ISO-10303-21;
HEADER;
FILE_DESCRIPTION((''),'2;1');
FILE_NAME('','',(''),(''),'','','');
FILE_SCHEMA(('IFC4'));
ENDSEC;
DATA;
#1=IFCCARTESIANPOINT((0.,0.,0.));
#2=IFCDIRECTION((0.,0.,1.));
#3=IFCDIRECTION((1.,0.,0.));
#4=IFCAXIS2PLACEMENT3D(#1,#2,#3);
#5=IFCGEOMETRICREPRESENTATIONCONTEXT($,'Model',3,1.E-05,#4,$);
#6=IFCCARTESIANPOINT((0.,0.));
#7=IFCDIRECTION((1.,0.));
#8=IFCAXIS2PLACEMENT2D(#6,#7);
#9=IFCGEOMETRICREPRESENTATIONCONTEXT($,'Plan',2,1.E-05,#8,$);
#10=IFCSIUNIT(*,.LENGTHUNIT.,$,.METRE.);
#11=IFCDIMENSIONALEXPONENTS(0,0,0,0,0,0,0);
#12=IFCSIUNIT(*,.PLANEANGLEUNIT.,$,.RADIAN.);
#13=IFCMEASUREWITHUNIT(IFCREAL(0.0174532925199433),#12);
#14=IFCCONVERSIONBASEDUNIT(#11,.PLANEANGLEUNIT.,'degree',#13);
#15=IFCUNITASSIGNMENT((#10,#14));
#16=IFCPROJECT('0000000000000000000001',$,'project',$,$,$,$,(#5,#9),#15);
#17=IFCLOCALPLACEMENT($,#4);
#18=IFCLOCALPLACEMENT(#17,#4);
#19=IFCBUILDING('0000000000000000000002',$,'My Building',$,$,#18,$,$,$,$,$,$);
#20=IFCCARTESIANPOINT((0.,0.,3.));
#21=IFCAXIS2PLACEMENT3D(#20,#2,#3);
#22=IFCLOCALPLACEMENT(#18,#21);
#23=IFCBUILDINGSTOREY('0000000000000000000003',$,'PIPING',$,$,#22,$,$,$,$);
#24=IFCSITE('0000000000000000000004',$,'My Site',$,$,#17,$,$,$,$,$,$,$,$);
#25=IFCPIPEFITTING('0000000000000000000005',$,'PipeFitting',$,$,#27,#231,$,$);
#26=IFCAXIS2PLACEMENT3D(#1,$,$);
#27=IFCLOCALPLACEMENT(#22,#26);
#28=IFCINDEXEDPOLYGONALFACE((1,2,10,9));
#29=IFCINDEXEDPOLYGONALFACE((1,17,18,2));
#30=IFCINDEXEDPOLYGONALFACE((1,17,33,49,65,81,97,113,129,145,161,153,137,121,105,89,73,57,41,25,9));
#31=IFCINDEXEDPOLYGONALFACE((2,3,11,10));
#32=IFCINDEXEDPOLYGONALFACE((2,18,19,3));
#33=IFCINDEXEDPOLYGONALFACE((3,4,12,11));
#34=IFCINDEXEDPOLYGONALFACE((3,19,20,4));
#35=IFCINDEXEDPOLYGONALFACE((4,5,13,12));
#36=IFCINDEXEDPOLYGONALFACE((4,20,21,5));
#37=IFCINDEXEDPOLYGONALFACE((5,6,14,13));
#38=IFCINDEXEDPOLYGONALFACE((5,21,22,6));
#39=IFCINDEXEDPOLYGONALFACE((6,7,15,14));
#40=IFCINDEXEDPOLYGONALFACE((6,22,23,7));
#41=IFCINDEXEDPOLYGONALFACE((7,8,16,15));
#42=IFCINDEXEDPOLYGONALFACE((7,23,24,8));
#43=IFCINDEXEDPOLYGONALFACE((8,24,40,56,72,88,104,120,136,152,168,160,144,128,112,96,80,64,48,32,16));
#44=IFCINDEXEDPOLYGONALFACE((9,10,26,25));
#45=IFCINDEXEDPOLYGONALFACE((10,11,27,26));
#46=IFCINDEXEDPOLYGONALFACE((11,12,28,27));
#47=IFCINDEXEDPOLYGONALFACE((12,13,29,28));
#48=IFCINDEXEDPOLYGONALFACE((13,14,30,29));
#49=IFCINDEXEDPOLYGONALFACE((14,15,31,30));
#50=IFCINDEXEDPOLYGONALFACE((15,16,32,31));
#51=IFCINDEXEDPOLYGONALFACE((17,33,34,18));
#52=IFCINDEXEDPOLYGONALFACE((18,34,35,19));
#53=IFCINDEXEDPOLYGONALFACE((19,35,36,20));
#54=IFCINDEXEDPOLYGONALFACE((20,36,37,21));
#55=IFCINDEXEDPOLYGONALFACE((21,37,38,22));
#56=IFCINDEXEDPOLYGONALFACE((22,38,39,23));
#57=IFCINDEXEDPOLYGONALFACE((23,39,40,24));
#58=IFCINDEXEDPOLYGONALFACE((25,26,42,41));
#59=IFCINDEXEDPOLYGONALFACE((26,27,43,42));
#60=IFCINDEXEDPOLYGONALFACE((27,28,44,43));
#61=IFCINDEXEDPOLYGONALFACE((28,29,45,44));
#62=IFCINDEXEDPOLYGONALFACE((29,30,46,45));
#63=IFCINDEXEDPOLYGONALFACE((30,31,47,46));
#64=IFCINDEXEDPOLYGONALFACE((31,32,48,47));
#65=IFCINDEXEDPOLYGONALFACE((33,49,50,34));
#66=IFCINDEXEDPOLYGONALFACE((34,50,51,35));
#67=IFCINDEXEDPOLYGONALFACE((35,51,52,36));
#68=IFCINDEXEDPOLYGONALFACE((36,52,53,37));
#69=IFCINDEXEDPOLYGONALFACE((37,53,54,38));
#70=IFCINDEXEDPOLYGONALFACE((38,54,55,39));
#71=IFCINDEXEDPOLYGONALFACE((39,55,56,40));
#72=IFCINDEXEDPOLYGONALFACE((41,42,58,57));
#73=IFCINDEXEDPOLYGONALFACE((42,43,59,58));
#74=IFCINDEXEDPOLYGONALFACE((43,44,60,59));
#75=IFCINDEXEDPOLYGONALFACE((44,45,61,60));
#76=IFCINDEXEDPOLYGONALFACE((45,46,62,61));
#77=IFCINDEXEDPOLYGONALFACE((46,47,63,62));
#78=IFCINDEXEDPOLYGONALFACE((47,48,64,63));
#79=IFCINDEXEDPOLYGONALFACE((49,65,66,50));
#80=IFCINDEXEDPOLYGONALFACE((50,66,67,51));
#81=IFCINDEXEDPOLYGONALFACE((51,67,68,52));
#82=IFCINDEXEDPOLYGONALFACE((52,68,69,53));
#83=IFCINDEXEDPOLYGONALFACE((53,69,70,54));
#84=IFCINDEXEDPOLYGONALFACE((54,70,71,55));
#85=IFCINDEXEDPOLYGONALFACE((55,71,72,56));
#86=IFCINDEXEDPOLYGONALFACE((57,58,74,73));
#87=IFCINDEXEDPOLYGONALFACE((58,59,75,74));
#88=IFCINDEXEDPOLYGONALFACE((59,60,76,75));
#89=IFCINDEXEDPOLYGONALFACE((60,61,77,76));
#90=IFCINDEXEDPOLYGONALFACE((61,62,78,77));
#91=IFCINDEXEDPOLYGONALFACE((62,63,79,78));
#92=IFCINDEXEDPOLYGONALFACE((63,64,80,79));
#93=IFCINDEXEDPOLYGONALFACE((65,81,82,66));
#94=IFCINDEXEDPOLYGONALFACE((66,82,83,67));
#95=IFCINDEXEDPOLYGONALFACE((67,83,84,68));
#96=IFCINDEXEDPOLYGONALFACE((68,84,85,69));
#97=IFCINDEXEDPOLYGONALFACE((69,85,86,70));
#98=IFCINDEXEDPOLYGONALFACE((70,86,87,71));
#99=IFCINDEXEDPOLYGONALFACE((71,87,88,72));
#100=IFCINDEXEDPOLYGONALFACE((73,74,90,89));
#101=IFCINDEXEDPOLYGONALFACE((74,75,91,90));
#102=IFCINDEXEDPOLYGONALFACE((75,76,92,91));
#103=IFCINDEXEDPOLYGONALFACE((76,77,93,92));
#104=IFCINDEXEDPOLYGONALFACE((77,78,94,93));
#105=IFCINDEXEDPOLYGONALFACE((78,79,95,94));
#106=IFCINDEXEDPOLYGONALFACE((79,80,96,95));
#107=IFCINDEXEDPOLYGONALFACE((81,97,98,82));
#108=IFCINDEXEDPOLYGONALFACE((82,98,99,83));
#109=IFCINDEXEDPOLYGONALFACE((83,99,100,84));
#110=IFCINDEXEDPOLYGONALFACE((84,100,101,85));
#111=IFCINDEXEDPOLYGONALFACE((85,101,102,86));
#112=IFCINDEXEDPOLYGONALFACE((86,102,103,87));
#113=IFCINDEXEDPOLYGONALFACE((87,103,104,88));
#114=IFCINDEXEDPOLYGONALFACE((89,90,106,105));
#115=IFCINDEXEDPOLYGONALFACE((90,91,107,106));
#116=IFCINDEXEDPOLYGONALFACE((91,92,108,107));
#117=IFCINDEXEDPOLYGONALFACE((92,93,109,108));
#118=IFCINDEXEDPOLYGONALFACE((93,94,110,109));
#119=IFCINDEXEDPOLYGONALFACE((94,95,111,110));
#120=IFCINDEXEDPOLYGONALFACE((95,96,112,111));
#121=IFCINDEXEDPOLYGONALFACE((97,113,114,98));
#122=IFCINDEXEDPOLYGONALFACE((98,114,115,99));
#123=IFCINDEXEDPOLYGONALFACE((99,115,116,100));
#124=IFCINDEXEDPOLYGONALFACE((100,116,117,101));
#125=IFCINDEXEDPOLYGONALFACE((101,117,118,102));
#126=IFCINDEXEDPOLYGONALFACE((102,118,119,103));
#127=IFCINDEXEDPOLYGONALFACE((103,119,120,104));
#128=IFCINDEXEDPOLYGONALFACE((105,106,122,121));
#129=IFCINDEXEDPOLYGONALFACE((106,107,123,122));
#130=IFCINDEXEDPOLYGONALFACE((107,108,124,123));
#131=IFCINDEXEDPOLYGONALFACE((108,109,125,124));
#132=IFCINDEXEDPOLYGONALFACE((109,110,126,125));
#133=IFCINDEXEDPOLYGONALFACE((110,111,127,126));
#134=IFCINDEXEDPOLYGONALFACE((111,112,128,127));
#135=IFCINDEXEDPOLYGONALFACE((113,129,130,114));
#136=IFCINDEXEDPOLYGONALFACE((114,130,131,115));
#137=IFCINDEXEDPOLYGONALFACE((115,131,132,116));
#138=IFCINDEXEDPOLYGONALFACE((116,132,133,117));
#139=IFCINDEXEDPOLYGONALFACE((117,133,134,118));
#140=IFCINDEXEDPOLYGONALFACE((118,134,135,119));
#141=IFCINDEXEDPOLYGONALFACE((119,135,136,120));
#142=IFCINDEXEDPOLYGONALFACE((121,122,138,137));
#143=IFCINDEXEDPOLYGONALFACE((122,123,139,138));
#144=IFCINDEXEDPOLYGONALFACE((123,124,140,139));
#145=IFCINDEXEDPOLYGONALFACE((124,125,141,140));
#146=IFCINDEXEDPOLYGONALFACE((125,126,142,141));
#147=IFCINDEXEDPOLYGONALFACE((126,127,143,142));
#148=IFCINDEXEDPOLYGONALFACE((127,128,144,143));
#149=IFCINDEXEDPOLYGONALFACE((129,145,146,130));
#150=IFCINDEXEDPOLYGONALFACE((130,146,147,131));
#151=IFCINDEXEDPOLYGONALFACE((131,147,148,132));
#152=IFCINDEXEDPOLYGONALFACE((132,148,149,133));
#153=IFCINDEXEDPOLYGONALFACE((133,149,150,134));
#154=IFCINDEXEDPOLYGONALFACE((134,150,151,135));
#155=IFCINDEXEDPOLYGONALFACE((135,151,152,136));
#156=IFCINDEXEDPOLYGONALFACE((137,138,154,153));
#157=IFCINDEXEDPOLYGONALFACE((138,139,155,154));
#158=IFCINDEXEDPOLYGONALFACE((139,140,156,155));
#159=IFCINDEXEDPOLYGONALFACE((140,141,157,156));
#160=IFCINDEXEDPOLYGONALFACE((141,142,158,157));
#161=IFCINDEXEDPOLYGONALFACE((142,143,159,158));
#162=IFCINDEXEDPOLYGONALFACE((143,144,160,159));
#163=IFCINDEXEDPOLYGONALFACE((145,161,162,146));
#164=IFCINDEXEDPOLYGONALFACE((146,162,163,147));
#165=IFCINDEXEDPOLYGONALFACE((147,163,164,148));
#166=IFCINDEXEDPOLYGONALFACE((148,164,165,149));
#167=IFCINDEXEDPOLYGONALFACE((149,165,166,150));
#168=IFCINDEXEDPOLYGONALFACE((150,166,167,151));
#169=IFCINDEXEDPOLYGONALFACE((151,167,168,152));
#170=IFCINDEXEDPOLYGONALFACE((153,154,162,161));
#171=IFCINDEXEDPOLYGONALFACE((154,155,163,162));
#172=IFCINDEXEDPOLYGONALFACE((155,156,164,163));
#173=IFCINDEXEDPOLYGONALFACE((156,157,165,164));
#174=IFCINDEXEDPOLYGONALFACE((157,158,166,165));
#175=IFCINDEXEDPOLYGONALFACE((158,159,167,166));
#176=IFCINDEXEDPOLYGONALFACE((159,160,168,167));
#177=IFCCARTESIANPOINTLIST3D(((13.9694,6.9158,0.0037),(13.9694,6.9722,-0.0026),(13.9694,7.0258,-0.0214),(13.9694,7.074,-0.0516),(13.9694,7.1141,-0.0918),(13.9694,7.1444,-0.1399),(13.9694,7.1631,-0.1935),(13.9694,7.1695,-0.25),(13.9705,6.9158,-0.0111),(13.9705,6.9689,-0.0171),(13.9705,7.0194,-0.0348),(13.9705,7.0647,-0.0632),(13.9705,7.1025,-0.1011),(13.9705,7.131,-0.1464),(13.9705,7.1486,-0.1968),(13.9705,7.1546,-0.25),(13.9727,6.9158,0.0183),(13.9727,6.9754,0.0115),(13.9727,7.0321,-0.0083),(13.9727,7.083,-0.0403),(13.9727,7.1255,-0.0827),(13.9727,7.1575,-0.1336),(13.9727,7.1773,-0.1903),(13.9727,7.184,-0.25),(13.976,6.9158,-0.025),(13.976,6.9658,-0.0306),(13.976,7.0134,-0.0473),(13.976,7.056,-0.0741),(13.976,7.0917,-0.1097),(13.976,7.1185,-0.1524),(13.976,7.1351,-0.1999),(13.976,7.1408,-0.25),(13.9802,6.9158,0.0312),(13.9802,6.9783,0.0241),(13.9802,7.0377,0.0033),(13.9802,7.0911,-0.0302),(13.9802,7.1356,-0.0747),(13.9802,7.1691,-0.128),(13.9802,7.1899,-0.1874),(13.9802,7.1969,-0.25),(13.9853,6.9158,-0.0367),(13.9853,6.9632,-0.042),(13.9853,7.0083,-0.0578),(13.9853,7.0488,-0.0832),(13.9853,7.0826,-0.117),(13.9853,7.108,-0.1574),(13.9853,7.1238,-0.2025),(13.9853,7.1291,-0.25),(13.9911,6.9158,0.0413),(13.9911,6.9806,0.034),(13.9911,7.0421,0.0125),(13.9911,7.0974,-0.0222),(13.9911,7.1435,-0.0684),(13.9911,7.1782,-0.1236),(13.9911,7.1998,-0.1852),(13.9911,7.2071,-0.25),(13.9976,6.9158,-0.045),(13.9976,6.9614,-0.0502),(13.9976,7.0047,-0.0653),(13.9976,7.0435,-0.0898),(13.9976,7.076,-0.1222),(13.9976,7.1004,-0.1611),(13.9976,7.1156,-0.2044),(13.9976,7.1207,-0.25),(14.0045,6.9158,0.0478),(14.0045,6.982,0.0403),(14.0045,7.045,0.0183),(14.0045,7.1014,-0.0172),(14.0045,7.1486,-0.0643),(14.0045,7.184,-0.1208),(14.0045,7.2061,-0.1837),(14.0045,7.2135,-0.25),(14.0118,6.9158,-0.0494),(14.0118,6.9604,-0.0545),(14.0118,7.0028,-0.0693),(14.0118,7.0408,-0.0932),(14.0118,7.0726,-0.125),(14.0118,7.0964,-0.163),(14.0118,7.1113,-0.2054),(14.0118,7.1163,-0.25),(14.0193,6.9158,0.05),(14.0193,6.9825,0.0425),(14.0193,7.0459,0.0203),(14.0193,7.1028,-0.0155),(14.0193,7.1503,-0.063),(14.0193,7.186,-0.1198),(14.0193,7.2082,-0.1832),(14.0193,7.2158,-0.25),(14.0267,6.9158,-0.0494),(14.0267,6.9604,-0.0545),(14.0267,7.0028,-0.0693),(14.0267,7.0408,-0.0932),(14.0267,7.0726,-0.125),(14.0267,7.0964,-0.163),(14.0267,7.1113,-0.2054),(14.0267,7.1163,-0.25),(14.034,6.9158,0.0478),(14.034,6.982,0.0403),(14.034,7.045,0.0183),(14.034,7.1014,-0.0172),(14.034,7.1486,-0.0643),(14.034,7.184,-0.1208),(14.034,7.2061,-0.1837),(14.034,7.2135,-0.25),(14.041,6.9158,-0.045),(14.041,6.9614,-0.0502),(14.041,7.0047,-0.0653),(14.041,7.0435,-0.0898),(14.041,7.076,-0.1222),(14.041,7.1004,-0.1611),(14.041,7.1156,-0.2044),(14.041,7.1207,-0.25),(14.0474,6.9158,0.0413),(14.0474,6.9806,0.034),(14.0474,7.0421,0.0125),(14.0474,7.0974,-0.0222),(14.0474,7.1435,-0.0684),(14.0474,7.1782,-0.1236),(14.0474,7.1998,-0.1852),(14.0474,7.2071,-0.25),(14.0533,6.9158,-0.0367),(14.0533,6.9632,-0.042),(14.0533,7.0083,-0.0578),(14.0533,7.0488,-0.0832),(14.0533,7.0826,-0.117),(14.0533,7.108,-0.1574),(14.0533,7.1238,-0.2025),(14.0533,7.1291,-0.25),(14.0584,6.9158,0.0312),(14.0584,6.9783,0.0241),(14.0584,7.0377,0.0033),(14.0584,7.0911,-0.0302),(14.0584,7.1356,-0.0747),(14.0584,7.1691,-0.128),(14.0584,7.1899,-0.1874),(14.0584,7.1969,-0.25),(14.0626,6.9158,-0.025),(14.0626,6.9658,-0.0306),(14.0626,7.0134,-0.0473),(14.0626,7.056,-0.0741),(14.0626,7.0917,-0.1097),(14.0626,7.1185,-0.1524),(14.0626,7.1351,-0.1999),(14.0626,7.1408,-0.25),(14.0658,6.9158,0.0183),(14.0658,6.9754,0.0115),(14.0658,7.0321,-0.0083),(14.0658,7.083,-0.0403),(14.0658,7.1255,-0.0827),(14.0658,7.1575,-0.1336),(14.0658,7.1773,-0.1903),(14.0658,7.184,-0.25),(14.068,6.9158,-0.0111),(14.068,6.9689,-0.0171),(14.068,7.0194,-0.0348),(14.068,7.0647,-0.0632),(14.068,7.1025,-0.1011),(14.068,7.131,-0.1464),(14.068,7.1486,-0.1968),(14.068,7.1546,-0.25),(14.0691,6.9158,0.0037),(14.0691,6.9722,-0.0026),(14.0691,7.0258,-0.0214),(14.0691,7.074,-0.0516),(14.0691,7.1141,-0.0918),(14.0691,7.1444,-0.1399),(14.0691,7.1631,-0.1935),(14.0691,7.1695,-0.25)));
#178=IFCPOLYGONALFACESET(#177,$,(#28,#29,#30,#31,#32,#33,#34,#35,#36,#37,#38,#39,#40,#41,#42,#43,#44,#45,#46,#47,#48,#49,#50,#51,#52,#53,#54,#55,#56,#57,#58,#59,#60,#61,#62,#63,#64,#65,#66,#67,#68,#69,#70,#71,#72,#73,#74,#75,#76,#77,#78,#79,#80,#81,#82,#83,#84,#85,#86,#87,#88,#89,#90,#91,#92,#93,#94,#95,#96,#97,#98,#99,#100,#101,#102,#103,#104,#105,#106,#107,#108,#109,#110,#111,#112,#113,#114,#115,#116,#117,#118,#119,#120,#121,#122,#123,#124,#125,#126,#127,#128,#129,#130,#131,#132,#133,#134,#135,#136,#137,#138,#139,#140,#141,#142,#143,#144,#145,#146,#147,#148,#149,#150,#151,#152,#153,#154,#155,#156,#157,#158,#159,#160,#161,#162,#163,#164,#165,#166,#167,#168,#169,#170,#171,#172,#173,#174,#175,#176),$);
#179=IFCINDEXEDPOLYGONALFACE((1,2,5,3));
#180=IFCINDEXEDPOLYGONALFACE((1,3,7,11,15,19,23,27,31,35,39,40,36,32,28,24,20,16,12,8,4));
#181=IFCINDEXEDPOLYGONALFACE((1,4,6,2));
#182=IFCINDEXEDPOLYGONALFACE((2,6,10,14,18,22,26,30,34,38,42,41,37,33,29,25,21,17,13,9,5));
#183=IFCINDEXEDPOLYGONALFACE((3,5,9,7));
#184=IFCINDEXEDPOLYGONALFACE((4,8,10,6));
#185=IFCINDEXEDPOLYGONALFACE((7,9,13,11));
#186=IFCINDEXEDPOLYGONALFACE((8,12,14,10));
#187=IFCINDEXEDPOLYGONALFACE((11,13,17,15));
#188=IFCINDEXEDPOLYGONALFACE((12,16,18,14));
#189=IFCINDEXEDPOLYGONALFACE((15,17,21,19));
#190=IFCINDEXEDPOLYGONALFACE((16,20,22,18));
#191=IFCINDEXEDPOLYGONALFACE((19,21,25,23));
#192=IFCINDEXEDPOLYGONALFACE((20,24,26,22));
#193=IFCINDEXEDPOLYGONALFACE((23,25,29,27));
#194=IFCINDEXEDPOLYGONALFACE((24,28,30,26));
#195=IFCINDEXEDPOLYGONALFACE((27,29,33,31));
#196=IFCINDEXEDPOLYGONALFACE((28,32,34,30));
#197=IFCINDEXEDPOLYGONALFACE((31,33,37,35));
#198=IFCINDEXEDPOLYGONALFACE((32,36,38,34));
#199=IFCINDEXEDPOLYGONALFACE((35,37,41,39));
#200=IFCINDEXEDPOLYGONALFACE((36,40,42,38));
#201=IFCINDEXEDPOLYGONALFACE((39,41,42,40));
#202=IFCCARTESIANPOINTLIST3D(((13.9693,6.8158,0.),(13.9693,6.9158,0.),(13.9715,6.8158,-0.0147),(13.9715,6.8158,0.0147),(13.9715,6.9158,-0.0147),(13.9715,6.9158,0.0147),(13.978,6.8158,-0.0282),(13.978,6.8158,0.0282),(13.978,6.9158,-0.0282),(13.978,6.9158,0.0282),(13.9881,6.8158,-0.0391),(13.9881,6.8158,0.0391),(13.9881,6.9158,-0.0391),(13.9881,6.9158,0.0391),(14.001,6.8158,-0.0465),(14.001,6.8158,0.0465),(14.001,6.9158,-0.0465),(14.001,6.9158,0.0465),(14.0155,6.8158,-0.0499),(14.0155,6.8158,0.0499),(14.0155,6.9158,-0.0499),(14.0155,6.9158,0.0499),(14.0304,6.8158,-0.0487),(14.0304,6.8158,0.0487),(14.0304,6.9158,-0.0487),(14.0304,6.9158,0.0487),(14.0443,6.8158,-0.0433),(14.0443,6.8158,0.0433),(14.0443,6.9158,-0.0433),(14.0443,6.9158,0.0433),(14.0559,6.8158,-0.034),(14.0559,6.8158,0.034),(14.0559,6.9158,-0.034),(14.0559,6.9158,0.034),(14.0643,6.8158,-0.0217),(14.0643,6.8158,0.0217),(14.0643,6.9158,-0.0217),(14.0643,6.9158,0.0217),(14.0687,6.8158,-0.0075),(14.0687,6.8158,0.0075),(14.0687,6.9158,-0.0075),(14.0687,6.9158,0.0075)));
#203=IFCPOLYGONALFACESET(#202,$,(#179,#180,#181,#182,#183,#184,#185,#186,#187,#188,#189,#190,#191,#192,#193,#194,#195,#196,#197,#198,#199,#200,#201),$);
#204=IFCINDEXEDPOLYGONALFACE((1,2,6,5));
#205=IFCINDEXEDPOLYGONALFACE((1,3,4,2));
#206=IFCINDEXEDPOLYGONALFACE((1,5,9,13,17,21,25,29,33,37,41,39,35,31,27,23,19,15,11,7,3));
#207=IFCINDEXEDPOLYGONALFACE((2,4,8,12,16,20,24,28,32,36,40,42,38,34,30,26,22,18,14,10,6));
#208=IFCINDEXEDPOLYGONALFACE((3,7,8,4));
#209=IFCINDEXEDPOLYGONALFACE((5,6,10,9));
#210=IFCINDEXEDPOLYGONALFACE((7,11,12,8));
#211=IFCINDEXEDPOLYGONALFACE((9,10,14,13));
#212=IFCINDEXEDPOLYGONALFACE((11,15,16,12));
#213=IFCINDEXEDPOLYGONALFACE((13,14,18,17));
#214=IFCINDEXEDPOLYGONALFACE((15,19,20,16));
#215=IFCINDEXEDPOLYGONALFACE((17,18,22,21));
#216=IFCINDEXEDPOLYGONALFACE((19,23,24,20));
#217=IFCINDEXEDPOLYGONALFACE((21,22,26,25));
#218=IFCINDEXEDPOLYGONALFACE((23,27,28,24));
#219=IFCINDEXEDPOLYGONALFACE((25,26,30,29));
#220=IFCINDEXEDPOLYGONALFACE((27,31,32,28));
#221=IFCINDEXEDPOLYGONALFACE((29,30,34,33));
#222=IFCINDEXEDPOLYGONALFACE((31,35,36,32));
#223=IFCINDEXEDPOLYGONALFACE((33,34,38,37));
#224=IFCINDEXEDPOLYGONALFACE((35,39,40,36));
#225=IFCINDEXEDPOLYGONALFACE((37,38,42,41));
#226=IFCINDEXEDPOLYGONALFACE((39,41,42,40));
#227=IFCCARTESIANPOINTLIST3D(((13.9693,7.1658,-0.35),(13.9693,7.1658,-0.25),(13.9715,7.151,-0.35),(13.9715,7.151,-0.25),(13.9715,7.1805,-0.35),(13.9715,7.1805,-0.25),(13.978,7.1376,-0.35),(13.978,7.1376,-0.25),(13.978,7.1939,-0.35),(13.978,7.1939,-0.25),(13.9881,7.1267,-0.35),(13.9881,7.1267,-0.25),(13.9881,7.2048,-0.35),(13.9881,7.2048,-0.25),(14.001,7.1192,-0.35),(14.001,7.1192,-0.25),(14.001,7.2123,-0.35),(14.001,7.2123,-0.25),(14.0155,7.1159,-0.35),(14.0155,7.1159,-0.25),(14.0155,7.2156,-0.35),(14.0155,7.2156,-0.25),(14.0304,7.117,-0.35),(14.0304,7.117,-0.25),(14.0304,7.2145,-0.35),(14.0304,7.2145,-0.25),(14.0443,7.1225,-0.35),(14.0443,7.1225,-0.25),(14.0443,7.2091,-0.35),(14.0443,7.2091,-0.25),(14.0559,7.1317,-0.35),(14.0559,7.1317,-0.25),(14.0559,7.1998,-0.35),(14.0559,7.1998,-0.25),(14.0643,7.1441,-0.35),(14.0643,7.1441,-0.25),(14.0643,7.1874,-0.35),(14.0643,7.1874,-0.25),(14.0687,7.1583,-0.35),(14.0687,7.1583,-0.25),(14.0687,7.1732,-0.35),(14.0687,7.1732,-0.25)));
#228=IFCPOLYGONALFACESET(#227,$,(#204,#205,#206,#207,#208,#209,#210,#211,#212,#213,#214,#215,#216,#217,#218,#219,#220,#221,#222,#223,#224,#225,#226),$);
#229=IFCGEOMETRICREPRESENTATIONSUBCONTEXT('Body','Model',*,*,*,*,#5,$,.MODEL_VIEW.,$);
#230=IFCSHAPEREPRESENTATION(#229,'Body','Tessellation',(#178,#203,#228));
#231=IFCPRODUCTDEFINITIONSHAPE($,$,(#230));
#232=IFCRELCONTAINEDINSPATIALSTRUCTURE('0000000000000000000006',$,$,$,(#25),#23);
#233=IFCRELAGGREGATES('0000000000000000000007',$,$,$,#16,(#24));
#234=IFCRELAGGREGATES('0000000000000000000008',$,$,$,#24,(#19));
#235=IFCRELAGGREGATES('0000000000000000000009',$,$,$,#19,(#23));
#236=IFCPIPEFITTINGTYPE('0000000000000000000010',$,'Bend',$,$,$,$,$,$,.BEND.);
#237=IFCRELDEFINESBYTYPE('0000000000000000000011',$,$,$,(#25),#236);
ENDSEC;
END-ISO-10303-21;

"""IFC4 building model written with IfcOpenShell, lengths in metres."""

from ifc_helpers import new_model, entity, si_unit, converted_unit, frame, origin_with_axes, origin_2d_with_axis, place, context, subcontext, project, spatial, circle, extrude, source, transform, mapped, type_object, type_shapes, element, save


model = new_model("IFC4")

# Units and contexts
model_context = context("Model", 3, precision=1e-05, world=origin_with_axes())
plan_context = context("Plan", 2, precision=1e-05, world=origin_2d_with_axis())
body_context = subcontext(model_context, "Body", "Model", "MODEL_VIEW")
ifc_project = project(units=[si_unit("LENGTHUNIT", "METRE"), converted_unit("PLANEANGLEUNIT", "degree", entity("IfcReal", 0.0174532925199433), si_unit("PLANEANGLEUNIT", "RADIAN"), dimensions=[0, 0, 0, 0, 0, 0, 0])], contexts=[model_context, plan_context])

# Site, building, storey
site_placement = place(None, origin_with_axes())
site = spatial("IfcSite", under=ifc_project, at=site_placement, Name="My Site")
building_placement = place(site_placement, origin_with_axes())
building = spatial("IfcBuilding", under=site, at=building_placement, Name="My Building")
storey_placement = place(building_placement, frame((0.0, 0.0, 3.0), z_axis=(0.0, 0.0, 1.0), x_axis=(1.0, 0.0, 0.0)))
storey = spatial("IfcBuildingStorey", under=building, at=storey_placement, Name="PIPING")

# Pipe fitting
pipe_fitting_type = type_object("IfcPipeFittingType", Name="Bend", PredefinedType="BEND")
shared_shape = source(origin_with_axes(), body_context, "Body", "SolidModel", [
    entity("IfcSweptDiskSolid", entity("IfcIndexedPolyCurve", entity("IfcCartesianPointList3D", [[0.0, 0.0, 0.1], [0.0, -0.0732, 0.2768], [0.0, -0.25, 0.35]]), [entity("IfcArcIndex", [1, 2, 3])]), 0.05),
    extrude(circle(Radius=0.05), origin_with_axes(), (0.0, 0.0, 1.0), 0.1),
    extrude(circle(Radius=0.05), frame((0.0, -0.25, 0.35), z_axis=(0.0, -1.0, 0.0), x_axis=(1.0, 0.0, 0.0)), (0.0, 0.0, 1.0), 0.1),
])
type_shapes(pipe_fitting_type, [shared_shape])
for number, where, z_axis, x_axis, name in (
    (1, (14.0193, 6.8158, 0.0), (0.0, 1.0, 0.0), (-1.0, 0.0, 0.0), "PipeFitting"),
):
    element("IfcPipeFitting", number, at=place(storey_placement, frame(where, z_axis=z_axis, x_axis=x_axis)), inside=storey, type_object=pipe_fitting_type, Name=name, context=body_context, shape_type="MappedRepresentation", body=[
        mapped(shared_shape, transform((0.0, 0.0, 0.0), x_axis=(1.0, 0.0, 0.0), y_axis=(0.0, 1.0, 0.0), z_axis=(0.0, 0.0, 1.0), scale=1.0)),
    ])

save(model, "model.ifc")
